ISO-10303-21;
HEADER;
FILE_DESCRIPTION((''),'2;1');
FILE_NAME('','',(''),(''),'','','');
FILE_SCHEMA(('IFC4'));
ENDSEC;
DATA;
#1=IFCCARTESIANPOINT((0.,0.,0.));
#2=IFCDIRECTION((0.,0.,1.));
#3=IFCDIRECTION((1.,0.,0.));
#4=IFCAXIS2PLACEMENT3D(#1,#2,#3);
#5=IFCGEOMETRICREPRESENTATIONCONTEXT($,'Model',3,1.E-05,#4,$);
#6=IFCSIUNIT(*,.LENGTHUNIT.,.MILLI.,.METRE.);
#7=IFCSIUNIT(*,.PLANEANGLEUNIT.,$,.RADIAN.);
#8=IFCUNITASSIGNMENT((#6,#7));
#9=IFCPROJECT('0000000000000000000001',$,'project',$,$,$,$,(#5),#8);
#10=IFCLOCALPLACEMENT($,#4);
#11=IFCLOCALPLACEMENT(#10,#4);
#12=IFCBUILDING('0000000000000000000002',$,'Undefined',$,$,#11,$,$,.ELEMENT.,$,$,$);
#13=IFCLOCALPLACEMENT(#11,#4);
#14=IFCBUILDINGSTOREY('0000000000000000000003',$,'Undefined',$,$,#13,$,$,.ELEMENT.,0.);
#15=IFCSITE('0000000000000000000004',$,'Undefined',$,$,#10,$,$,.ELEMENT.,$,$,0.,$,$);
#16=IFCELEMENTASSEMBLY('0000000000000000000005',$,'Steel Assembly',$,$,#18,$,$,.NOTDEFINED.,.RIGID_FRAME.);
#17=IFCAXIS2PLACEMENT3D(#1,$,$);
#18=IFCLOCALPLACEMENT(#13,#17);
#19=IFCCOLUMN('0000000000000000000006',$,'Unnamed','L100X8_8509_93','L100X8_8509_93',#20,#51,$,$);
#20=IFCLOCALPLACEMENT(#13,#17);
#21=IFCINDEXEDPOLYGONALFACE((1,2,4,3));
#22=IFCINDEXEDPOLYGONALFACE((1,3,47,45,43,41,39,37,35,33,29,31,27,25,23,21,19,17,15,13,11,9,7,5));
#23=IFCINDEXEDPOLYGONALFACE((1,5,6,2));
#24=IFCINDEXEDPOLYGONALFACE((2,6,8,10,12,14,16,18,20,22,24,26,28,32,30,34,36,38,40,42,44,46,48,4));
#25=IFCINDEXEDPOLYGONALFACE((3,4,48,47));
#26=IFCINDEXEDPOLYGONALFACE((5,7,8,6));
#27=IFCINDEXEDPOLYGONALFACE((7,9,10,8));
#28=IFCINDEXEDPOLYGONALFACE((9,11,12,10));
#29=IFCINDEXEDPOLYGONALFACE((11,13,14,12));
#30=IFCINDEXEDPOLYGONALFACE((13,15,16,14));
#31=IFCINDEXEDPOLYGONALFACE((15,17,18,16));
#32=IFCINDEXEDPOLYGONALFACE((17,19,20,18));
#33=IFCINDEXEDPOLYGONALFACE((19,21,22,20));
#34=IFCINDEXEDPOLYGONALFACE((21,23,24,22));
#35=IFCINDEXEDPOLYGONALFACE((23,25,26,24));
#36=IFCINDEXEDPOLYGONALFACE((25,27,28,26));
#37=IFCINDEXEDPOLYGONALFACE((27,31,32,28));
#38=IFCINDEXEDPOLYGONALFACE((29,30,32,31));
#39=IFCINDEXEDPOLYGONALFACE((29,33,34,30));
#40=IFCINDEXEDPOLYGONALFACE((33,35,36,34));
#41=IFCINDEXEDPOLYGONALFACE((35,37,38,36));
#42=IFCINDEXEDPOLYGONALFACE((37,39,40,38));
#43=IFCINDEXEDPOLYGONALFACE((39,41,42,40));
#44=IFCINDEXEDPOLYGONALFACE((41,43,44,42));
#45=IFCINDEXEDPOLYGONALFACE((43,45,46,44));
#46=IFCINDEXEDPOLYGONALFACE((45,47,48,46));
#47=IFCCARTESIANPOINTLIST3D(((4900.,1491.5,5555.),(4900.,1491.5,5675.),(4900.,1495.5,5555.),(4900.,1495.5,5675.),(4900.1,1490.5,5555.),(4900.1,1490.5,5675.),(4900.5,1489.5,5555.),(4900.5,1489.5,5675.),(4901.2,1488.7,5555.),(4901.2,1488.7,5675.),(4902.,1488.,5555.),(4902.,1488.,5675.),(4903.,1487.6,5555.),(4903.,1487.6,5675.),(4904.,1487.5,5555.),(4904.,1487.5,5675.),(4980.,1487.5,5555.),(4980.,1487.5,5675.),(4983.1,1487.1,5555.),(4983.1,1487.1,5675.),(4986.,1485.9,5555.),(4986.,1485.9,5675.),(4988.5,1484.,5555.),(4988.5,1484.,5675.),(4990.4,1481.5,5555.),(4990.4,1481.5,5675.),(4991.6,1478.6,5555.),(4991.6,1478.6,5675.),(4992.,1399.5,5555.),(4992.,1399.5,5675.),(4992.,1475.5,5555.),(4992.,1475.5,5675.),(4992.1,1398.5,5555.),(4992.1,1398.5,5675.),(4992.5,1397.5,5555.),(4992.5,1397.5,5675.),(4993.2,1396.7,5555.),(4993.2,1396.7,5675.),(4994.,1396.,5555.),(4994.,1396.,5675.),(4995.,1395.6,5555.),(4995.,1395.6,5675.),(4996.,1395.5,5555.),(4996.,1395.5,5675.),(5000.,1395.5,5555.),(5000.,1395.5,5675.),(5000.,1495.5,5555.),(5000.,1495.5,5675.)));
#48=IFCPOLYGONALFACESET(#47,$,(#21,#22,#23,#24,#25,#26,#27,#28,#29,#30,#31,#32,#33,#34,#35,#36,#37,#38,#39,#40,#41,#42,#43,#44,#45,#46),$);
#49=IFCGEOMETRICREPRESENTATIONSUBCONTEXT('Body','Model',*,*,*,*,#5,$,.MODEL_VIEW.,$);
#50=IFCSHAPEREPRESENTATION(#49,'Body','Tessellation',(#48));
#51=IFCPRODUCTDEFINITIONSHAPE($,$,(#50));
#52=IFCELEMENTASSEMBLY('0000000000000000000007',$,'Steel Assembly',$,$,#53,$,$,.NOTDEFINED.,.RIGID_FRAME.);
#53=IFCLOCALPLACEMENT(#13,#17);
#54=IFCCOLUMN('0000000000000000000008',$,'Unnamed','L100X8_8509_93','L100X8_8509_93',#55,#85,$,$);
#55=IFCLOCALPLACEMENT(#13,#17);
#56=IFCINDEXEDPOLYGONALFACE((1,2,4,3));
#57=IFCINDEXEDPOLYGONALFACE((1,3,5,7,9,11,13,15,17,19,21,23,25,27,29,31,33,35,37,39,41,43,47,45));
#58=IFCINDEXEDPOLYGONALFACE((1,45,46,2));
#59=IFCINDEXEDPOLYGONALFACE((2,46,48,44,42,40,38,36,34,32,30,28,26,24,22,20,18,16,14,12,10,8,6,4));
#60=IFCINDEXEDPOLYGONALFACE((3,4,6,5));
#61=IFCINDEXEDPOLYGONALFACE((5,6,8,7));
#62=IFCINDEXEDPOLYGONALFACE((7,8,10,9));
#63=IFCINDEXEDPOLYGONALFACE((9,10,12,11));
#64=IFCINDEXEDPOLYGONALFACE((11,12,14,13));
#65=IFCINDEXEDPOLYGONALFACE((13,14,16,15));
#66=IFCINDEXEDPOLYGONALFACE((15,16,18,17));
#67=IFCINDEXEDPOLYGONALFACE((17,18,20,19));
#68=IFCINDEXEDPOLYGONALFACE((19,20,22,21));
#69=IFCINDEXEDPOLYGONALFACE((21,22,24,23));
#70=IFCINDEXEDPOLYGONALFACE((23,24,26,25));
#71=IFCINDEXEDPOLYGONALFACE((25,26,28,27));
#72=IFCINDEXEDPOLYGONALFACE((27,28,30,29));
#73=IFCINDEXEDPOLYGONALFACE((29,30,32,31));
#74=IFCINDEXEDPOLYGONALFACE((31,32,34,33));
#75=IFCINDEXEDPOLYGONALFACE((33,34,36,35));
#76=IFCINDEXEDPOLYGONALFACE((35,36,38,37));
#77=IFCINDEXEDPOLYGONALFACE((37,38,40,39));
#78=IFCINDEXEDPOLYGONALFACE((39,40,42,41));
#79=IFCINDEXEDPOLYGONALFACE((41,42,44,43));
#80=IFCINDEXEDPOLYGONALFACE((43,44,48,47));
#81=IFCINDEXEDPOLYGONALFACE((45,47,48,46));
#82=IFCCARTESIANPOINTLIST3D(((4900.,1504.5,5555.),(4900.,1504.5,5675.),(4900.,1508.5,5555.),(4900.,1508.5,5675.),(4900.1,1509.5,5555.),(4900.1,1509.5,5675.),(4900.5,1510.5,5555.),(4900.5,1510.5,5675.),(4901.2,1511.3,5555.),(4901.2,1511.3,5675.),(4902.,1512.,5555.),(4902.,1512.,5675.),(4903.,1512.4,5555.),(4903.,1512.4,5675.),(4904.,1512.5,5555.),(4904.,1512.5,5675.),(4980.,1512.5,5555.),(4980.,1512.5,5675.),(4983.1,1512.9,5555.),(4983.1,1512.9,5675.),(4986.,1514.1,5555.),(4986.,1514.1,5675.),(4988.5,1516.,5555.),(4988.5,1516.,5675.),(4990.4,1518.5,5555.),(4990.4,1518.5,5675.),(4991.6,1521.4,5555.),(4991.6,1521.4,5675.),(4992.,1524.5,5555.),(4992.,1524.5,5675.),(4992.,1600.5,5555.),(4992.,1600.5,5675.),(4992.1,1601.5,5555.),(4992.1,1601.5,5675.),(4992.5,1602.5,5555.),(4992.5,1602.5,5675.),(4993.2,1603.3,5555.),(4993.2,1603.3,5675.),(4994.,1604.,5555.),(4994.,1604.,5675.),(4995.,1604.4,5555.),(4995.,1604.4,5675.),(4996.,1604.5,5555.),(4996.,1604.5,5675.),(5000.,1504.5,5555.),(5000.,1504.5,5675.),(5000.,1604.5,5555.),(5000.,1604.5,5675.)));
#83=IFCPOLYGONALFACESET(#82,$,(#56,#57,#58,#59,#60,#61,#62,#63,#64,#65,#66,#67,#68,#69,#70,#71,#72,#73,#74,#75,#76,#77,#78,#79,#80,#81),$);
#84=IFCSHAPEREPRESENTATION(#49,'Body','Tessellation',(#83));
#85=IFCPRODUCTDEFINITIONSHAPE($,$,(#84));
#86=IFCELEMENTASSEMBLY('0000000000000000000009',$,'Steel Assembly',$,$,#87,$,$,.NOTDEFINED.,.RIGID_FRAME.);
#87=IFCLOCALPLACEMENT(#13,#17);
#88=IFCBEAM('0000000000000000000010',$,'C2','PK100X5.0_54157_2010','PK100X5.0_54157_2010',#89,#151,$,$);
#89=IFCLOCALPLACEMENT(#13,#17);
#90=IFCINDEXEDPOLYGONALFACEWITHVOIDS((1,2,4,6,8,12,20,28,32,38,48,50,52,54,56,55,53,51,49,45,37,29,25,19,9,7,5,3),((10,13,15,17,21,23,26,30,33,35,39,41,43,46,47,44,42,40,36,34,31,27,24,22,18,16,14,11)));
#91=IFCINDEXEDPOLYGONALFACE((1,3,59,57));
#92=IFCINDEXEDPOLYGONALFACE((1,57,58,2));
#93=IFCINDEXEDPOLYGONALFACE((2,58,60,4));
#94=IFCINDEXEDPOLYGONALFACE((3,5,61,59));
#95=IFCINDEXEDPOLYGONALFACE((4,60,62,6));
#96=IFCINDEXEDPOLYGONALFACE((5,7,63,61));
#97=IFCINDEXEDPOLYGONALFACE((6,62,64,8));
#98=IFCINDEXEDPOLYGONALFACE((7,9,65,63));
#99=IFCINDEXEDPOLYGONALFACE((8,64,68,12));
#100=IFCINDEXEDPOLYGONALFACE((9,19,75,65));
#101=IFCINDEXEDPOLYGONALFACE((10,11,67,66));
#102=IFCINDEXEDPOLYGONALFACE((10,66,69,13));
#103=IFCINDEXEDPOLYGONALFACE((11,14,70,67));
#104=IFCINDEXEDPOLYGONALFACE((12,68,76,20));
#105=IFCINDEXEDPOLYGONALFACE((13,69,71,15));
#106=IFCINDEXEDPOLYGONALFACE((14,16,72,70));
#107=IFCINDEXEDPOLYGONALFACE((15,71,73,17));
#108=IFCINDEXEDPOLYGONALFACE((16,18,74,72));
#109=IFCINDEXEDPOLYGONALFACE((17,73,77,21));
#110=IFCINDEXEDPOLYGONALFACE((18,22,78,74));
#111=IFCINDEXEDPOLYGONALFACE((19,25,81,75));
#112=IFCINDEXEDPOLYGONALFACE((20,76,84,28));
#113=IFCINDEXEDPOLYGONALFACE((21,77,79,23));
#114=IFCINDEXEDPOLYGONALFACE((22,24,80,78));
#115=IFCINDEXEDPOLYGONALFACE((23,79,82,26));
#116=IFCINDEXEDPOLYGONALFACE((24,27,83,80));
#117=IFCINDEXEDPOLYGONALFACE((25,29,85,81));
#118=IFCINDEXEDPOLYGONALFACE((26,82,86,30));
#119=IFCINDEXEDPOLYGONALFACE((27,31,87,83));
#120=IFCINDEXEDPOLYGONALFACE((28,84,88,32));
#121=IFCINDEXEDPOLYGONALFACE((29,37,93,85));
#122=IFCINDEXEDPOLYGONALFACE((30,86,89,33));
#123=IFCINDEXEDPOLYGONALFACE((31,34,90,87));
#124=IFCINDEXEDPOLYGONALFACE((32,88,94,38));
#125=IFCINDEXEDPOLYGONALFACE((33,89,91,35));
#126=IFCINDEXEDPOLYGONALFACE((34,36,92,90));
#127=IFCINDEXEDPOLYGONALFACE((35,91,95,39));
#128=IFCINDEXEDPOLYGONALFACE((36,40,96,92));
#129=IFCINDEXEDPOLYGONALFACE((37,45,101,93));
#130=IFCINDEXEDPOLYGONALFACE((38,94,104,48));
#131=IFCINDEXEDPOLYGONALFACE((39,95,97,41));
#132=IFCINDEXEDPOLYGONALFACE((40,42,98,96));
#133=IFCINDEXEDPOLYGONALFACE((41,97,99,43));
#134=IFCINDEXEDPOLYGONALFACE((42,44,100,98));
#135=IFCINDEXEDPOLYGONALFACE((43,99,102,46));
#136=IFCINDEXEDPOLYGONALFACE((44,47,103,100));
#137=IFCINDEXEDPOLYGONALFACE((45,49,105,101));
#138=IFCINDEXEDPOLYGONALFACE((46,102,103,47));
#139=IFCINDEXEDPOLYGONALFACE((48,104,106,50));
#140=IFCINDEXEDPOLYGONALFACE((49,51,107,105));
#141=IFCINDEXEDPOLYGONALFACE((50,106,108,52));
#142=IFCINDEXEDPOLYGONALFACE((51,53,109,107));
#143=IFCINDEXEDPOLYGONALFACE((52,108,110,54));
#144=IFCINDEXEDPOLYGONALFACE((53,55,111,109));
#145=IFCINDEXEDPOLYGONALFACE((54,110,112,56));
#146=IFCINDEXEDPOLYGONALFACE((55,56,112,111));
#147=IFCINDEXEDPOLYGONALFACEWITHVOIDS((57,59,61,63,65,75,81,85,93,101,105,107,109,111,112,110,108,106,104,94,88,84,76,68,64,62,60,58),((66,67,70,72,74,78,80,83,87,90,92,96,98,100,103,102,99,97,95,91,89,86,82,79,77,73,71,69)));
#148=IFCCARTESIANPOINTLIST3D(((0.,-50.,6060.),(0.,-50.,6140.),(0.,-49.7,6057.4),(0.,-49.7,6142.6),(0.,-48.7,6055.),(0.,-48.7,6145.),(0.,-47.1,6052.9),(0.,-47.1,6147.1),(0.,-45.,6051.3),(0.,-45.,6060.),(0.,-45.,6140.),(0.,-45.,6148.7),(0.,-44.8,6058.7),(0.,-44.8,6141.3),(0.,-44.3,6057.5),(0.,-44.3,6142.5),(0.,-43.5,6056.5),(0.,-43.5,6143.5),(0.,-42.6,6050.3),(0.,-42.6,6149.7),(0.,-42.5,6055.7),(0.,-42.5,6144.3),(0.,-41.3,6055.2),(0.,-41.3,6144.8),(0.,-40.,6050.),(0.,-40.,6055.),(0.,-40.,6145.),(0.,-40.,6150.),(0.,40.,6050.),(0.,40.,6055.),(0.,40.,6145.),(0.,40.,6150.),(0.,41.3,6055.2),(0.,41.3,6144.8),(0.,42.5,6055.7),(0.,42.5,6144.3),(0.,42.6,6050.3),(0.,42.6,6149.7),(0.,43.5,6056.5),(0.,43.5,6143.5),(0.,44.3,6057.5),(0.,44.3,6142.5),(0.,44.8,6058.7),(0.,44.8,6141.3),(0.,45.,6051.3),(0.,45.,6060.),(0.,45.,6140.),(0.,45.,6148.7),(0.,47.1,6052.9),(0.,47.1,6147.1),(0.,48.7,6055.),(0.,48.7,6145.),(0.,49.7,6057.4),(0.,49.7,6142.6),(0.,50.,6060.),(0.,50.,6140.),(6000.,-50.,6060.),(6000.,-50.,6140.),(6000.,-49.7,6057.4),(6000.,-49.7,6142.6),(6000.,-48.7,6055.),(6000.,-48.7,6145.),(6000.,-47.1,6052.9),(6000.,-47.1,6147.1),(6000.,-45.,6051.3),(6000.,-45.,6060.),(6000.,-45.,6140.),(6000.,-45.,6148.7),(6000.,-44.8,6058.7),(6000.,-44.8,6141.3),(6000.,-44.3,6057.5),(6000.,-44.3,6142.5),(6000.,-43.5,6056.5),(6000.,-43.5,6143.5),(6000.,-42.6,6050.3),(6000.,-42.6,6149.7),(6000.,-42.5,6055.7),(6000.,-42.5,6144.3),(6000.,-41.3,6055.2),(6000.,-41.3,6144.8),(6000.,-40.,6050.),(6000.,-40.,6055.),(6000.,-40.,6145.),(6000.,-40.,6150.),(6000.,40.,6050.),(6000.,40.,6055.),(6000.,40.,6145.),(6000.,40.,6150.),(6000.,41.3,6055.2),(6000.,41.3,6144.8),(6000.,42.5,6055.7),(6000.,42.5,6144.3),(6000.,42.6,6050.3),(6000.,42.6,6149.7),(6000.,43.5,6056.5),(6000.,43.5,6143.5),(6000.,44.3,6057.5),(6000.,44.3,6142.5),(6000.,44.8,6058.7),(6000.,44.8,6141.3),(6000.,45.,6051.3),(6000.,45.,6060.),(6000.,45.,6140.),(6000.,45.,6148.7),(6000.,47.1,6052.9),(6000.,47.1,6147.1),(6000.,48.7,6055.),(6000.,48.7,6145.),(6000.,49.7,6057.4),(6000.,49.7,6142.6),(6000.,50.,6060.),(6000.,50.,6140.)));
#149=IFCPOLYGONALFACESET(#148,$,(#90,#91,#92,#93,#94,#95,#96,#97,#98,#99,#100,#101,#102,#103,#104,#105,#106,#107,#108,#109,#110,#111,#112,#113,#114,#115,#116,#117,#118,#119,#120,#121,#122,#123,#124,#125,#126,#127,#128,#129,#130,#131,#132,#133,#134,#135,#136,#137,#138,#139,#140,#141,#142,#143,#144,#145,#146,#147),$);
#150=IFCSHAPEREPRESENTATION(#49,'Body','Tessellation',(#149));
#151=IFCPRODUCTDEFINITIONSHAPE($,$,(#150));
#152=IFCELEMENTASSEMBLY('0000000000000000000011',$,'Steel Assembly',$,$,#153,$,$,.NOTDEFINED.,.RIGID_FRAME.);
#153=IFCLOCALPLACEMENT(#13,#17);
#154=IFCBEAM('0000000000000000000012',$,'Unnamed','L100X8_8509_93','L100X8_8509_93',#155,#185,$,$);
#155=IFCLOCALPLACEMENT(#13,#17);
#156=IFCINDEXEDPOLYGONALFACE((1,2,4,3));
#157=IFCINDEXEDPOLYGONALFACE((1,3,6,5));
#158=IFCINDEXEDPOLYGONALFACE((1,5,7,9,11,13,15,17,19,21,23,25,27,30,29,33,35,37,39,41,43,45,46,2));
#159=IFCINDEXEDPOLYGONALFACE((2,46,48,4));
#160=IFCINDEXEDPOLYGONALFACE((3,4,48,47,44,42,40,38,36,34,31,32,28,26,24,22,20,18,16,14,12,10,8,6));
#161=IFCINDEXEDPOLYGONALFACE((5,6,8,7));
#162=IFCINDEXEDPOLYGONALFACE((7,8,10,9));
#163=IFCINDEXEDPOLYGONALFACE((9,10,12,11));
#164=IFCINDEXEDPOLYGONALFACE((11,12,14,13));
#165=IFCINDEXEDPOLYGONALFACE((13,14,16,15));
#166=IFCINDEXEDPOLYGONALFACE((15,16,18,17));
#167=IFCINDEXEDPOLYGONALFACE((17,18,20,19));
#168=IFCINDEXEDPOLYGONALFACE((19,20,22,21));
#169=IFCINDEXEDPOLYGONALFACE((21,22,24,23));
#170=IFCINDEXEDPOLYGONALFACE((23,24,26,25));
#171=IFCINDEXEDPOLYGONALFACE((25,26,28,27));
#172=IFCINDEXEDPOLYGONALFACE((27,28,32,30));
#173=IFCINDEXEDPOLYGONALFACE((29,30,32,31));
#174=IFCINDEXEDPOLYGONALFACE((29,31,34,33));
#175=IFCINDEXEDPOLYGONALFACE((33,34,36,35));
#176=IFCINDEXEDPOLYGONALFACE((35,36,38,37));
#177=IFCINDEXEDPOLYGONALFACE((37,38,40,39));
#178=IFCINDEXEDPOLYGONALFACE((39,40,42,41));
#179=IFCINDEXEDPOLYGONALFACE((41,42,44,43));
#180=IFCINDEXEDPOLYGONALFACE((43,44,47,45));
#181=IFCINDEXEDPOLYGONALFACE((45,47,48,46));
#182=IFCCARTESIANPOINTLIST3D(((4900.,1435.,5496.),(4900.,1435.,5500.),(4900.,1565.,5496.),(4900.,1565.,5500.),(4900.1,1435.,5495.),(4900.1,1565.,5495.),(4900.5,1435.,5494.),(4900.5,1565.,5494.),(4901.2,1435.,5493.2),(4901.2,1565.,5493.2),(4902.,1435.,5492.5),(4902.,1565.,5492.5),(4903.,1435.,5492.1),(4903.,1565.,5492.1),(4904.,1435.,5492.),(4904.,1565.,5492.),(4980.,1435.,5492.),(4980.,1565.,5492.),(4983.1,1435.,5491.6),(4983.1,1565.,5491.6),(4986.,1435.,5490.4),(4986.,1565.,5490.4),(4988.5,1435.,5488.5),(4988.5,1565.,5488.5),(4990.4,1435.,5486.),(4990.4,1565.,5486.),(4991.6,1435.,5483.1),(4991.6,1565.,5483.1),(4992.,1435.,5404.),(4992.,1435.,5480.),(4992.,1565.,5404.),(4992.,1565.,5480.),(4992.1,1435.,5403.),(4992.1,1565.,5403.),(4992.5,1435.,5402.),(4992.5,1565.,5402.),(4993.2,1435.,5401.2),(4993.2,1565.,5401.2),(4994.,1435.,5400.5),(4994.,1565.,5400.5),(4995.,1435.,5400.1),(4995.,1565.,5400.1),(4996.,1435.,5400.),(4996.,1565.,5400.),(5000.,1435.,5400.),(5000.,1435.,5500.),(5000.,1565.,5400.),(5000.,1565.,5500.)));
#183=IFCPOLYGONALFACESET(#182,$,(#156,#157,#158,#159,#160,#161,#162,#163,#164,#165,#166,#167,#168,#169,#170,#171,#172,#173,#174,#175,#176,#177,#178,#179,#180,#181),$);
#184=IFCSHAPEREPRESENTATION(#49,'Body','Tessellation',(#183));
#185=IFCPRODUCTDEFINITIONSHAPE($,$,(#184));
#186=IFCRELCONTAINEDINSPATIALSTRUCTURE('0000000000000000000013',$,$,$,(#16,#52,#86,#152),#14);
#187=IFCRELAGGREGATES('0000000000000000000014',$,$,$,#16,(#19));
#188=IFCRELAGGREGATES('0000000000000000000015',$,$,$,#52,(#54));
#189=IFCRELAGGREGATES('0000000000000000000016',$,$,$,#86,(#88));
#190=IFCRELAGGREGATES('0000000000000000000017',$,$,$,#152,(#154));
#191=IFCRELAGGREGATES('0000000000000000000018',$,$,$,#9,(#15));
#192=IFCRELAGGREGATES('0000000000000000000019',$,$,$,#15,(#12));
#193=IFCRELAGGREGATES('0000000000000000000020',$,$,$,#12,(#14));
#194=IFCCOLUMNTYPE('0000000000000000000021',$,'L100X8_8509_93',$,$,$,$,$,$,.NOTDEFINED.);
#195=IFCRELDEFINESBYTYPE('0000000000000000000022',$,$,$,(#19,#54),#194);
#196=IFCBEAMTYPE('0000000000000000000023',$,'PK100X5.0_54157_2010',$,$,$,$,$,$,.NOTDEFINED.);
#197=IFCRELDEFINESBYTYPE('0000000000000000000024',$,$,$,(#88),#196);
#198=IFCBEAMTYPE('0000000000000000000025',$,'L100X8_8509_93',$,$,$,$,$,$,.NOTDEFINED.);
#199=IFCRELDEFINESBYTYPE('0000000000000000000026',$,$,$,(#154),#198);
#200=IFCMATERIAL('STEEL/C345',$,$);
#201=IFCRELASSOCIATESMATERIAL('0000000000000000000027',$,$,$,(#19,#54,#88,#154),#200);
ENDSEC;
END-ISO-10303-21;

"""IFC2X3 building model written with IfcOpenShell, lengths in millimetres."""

from ifc_helpers import new_model, si_unit, frame, origin_with_axes, origin_2d_with_axis, place, context, subcontext, project, spatial, hollow_rectangle, l_section, extrude, material, type_object, element, aggregate, save


model = new_model("IFC2X3")

# Units and contexts
model_context = context("Model", 3, precision=1e-05, world=origin_with_axes())
body_context = subcontext(model_context, "Body", "Model", "MODEL_VIEW")
ifc_project = project(units=[si_unit("LENGTHUNIT", "METRE", prefix="MILLI"), si_unit("PLANEANGLEUNIT", "RADIAN")], contexts=[model_context])

# Site, building, storey
site_placement = place(None, origin_with_axes())
site = spatial("IfcSite", under=ifc_project, at=site_placement, Name="Undefined", CompositionType="ELEMENT", RefElevation=0.0)
building_placement = place(site_placement, origin_with_axes())
building = spatial("IfcBuilding", under=site, at=building_placement, Name="Undefined", CompositionType="ELEMENT")
storey_placement = place(building_placement, origin_with_axes())
storey = spatial("IfcBuildingStorey", under=building, at=storey_placement, Name="Undefined", CompositionType="ELEMENT", Elevation=0.0)

# Element assemblies, columns
assembly_1_placement = place(storey_placement, origin_with_axes())
assembly_1 = element("IfcElementAssembly", 1, at=assembly_1_placement, inside=storey, Name="Steel Assembly", AssemblyPlace="NOTDEFINED", PredefinedType="RIGID_FRAME")
ifc_material_1 = material(Name="STEEL/C345")
column_type = type_object("IfcColumnType", Name="L100X8_8509_93", PredefinedType="NOTDEFINED")
column_1_placement = place(assembly_1_placement, frame((4950.0, 1445.5, 5555.0), z_axis=(0.0, 0.0, 1.0), x_axis=(-1.0, 0.0, 0.0)))
column_1 = element("IfcColumn", 2, at=column_1_placement, type_object=column_type, material=ifc_material_1, Name="Unnamed", Description="L100X8_8509_93", ObjectType="L100X8_8509_93", context=body_context, shape_type="SweptSolid", body=[
    extrude(l_section(Depth=100.0, Width=100.0, Thickness=8.0, FilletRadius=12.0, EdgeRadius=4.0, at=origin_2d_with_axis()), frame((0.0, 0.0, 120.0), z_axis=(0.0, 0.0, -1.0), x_axis=(0.0, 1.0, 0.0)), (0.0, 0.0, 1.0), 120.0),
])
aggregate(assembly_1, [column_1])
assembly_2_placement = place(storey_placement, origin_with_axes())
assembly_2 = element("IfcElementAssembly", 3, at=assembly_2_placement, inside=storey, Name="Steel Assembly", AssemblyPlace="NOTDEFINED", PredefinedType="RIGID_FRAME")
column_2_placement = place(assembly_2_placement, frame((4950.0, 1554.5, 5555.0), z_axis=(0.0, 0.0, 1.0), x_axis=(0.0, 1.0, 0.0)))
column_2 = element("IfcColumn", 4, at=column_2_placement, type_object=column_type, material=ifc_material_1, Name="Unnamed", Description="L100X8_8509_93", ObjectType="L100X8_8509_93", context=body_context, shape_type="SweptSolid", body=[
    extrude(l_section(Depth=100.0, Width=100.0, Thickness=8.0, FilletRadius=12.0, EdgeRadius=4.0, at=origin_2d_with_axis()), frame((0.0, 0.0, 120.0), z_axis=(0.0, 0.0, -1.0), x_axis=(0.0, 1.0, 0.0)), (0.0, 0.0, 1.0), 120.0),
])
aggregate(assembly_2, [column_2])

# Element assemblies, beams
assembly_3_placement = place(storey_placement, origin_with_axes())
assembly_3 = element("IfcElementAssembly", 5, at=assembly_3_placement, inside=storey, Name="Steel Assembly", AssemblyPlace="NOTDEFINED", PredefinedType="RIGID_FRAME")
beam_type_1 = type_object("IfcBeamType", Name="PK100X5.0_54157_2010", PredefinedType="NOTDEFINED")
beam_1_placement = place(assembly_3_placement, frame((6000.0, 0.0, 6100.0), z_axis=(0.0, 0.0, 1.0), x_axis=(-1.0, 0.0, 0.0)))
beam_1 = element("IfcBeam", 6, at=beam_1_placement, type_object=beam_type_1, material=ifc_material_1, Name="C2", Description="PK100X5.0_54157_2010", ObjectType="PK100X5.0_54157_2010", context=body_context, shape_type="SweptSolid", body=[
    extrude(hollow_rectangle(XDim=100.0, YDim=100.0, WallThickness=5.0, InnerFilletRadius=5.0, OuterFilletRadius=10.0, at=origin_2d_with_axis()), frame((6000.0, 0.0, 0.0), z_axis=(-1.0, 0.0, 0.0), x_axis=(0.0, -1.0, 0.0)), (0.0, 0.0, 1.0), 6000.0),
])
aggregate(assembly_3, [beam_1])
assembly_4_placement = place(storey_placement, origin_with_axes())
assembly_4 = element("IfcElementAssembly", 7, at=assembly_4_placement, inside=storey, Name="Steel Assembly", AssemblyPlace="NOTDEFINED", PredefinedType="RIGID_FRAME")
beam_type_2 = type_object("IfcBeamType", Name="L100X8_8509_93", PredefinedType="NOTDEFINED")
beam_2_placement = place(assembly_4_placement, frame((4950.0, 1565.0, 5450.0), z_axis=(-1.0, 0.0, 0.0), x_axis=(0.0, -1.0, 0.0)))
beam_2 = element("IfcBeam", 8, at=beam_2_placement, type_object=beam_type_2, material=ifc_material_1, Name="Unnamed", Description="L100X8_8509_93", ObjectType="L100X8_8509_93", context=body_context, shape_type="SweptSolid", body=[
    extrude(l_section(Depth=100.0, Width=100.0, Thickness=8.0, FilletRadius=12.0, EdgeRadius=4.0, at=origin_2d_with_axis()), frame((130.0, 0.0, 0.0), z_axis=(-1.0, 0.0, 0.0), x_axis=(0.0, -1.0, 0.0)), (0.0, 0.0, 1.0), 130.0),
])
aggregate(assembly_4, [beam_2])

save(model, "model.ifc")
